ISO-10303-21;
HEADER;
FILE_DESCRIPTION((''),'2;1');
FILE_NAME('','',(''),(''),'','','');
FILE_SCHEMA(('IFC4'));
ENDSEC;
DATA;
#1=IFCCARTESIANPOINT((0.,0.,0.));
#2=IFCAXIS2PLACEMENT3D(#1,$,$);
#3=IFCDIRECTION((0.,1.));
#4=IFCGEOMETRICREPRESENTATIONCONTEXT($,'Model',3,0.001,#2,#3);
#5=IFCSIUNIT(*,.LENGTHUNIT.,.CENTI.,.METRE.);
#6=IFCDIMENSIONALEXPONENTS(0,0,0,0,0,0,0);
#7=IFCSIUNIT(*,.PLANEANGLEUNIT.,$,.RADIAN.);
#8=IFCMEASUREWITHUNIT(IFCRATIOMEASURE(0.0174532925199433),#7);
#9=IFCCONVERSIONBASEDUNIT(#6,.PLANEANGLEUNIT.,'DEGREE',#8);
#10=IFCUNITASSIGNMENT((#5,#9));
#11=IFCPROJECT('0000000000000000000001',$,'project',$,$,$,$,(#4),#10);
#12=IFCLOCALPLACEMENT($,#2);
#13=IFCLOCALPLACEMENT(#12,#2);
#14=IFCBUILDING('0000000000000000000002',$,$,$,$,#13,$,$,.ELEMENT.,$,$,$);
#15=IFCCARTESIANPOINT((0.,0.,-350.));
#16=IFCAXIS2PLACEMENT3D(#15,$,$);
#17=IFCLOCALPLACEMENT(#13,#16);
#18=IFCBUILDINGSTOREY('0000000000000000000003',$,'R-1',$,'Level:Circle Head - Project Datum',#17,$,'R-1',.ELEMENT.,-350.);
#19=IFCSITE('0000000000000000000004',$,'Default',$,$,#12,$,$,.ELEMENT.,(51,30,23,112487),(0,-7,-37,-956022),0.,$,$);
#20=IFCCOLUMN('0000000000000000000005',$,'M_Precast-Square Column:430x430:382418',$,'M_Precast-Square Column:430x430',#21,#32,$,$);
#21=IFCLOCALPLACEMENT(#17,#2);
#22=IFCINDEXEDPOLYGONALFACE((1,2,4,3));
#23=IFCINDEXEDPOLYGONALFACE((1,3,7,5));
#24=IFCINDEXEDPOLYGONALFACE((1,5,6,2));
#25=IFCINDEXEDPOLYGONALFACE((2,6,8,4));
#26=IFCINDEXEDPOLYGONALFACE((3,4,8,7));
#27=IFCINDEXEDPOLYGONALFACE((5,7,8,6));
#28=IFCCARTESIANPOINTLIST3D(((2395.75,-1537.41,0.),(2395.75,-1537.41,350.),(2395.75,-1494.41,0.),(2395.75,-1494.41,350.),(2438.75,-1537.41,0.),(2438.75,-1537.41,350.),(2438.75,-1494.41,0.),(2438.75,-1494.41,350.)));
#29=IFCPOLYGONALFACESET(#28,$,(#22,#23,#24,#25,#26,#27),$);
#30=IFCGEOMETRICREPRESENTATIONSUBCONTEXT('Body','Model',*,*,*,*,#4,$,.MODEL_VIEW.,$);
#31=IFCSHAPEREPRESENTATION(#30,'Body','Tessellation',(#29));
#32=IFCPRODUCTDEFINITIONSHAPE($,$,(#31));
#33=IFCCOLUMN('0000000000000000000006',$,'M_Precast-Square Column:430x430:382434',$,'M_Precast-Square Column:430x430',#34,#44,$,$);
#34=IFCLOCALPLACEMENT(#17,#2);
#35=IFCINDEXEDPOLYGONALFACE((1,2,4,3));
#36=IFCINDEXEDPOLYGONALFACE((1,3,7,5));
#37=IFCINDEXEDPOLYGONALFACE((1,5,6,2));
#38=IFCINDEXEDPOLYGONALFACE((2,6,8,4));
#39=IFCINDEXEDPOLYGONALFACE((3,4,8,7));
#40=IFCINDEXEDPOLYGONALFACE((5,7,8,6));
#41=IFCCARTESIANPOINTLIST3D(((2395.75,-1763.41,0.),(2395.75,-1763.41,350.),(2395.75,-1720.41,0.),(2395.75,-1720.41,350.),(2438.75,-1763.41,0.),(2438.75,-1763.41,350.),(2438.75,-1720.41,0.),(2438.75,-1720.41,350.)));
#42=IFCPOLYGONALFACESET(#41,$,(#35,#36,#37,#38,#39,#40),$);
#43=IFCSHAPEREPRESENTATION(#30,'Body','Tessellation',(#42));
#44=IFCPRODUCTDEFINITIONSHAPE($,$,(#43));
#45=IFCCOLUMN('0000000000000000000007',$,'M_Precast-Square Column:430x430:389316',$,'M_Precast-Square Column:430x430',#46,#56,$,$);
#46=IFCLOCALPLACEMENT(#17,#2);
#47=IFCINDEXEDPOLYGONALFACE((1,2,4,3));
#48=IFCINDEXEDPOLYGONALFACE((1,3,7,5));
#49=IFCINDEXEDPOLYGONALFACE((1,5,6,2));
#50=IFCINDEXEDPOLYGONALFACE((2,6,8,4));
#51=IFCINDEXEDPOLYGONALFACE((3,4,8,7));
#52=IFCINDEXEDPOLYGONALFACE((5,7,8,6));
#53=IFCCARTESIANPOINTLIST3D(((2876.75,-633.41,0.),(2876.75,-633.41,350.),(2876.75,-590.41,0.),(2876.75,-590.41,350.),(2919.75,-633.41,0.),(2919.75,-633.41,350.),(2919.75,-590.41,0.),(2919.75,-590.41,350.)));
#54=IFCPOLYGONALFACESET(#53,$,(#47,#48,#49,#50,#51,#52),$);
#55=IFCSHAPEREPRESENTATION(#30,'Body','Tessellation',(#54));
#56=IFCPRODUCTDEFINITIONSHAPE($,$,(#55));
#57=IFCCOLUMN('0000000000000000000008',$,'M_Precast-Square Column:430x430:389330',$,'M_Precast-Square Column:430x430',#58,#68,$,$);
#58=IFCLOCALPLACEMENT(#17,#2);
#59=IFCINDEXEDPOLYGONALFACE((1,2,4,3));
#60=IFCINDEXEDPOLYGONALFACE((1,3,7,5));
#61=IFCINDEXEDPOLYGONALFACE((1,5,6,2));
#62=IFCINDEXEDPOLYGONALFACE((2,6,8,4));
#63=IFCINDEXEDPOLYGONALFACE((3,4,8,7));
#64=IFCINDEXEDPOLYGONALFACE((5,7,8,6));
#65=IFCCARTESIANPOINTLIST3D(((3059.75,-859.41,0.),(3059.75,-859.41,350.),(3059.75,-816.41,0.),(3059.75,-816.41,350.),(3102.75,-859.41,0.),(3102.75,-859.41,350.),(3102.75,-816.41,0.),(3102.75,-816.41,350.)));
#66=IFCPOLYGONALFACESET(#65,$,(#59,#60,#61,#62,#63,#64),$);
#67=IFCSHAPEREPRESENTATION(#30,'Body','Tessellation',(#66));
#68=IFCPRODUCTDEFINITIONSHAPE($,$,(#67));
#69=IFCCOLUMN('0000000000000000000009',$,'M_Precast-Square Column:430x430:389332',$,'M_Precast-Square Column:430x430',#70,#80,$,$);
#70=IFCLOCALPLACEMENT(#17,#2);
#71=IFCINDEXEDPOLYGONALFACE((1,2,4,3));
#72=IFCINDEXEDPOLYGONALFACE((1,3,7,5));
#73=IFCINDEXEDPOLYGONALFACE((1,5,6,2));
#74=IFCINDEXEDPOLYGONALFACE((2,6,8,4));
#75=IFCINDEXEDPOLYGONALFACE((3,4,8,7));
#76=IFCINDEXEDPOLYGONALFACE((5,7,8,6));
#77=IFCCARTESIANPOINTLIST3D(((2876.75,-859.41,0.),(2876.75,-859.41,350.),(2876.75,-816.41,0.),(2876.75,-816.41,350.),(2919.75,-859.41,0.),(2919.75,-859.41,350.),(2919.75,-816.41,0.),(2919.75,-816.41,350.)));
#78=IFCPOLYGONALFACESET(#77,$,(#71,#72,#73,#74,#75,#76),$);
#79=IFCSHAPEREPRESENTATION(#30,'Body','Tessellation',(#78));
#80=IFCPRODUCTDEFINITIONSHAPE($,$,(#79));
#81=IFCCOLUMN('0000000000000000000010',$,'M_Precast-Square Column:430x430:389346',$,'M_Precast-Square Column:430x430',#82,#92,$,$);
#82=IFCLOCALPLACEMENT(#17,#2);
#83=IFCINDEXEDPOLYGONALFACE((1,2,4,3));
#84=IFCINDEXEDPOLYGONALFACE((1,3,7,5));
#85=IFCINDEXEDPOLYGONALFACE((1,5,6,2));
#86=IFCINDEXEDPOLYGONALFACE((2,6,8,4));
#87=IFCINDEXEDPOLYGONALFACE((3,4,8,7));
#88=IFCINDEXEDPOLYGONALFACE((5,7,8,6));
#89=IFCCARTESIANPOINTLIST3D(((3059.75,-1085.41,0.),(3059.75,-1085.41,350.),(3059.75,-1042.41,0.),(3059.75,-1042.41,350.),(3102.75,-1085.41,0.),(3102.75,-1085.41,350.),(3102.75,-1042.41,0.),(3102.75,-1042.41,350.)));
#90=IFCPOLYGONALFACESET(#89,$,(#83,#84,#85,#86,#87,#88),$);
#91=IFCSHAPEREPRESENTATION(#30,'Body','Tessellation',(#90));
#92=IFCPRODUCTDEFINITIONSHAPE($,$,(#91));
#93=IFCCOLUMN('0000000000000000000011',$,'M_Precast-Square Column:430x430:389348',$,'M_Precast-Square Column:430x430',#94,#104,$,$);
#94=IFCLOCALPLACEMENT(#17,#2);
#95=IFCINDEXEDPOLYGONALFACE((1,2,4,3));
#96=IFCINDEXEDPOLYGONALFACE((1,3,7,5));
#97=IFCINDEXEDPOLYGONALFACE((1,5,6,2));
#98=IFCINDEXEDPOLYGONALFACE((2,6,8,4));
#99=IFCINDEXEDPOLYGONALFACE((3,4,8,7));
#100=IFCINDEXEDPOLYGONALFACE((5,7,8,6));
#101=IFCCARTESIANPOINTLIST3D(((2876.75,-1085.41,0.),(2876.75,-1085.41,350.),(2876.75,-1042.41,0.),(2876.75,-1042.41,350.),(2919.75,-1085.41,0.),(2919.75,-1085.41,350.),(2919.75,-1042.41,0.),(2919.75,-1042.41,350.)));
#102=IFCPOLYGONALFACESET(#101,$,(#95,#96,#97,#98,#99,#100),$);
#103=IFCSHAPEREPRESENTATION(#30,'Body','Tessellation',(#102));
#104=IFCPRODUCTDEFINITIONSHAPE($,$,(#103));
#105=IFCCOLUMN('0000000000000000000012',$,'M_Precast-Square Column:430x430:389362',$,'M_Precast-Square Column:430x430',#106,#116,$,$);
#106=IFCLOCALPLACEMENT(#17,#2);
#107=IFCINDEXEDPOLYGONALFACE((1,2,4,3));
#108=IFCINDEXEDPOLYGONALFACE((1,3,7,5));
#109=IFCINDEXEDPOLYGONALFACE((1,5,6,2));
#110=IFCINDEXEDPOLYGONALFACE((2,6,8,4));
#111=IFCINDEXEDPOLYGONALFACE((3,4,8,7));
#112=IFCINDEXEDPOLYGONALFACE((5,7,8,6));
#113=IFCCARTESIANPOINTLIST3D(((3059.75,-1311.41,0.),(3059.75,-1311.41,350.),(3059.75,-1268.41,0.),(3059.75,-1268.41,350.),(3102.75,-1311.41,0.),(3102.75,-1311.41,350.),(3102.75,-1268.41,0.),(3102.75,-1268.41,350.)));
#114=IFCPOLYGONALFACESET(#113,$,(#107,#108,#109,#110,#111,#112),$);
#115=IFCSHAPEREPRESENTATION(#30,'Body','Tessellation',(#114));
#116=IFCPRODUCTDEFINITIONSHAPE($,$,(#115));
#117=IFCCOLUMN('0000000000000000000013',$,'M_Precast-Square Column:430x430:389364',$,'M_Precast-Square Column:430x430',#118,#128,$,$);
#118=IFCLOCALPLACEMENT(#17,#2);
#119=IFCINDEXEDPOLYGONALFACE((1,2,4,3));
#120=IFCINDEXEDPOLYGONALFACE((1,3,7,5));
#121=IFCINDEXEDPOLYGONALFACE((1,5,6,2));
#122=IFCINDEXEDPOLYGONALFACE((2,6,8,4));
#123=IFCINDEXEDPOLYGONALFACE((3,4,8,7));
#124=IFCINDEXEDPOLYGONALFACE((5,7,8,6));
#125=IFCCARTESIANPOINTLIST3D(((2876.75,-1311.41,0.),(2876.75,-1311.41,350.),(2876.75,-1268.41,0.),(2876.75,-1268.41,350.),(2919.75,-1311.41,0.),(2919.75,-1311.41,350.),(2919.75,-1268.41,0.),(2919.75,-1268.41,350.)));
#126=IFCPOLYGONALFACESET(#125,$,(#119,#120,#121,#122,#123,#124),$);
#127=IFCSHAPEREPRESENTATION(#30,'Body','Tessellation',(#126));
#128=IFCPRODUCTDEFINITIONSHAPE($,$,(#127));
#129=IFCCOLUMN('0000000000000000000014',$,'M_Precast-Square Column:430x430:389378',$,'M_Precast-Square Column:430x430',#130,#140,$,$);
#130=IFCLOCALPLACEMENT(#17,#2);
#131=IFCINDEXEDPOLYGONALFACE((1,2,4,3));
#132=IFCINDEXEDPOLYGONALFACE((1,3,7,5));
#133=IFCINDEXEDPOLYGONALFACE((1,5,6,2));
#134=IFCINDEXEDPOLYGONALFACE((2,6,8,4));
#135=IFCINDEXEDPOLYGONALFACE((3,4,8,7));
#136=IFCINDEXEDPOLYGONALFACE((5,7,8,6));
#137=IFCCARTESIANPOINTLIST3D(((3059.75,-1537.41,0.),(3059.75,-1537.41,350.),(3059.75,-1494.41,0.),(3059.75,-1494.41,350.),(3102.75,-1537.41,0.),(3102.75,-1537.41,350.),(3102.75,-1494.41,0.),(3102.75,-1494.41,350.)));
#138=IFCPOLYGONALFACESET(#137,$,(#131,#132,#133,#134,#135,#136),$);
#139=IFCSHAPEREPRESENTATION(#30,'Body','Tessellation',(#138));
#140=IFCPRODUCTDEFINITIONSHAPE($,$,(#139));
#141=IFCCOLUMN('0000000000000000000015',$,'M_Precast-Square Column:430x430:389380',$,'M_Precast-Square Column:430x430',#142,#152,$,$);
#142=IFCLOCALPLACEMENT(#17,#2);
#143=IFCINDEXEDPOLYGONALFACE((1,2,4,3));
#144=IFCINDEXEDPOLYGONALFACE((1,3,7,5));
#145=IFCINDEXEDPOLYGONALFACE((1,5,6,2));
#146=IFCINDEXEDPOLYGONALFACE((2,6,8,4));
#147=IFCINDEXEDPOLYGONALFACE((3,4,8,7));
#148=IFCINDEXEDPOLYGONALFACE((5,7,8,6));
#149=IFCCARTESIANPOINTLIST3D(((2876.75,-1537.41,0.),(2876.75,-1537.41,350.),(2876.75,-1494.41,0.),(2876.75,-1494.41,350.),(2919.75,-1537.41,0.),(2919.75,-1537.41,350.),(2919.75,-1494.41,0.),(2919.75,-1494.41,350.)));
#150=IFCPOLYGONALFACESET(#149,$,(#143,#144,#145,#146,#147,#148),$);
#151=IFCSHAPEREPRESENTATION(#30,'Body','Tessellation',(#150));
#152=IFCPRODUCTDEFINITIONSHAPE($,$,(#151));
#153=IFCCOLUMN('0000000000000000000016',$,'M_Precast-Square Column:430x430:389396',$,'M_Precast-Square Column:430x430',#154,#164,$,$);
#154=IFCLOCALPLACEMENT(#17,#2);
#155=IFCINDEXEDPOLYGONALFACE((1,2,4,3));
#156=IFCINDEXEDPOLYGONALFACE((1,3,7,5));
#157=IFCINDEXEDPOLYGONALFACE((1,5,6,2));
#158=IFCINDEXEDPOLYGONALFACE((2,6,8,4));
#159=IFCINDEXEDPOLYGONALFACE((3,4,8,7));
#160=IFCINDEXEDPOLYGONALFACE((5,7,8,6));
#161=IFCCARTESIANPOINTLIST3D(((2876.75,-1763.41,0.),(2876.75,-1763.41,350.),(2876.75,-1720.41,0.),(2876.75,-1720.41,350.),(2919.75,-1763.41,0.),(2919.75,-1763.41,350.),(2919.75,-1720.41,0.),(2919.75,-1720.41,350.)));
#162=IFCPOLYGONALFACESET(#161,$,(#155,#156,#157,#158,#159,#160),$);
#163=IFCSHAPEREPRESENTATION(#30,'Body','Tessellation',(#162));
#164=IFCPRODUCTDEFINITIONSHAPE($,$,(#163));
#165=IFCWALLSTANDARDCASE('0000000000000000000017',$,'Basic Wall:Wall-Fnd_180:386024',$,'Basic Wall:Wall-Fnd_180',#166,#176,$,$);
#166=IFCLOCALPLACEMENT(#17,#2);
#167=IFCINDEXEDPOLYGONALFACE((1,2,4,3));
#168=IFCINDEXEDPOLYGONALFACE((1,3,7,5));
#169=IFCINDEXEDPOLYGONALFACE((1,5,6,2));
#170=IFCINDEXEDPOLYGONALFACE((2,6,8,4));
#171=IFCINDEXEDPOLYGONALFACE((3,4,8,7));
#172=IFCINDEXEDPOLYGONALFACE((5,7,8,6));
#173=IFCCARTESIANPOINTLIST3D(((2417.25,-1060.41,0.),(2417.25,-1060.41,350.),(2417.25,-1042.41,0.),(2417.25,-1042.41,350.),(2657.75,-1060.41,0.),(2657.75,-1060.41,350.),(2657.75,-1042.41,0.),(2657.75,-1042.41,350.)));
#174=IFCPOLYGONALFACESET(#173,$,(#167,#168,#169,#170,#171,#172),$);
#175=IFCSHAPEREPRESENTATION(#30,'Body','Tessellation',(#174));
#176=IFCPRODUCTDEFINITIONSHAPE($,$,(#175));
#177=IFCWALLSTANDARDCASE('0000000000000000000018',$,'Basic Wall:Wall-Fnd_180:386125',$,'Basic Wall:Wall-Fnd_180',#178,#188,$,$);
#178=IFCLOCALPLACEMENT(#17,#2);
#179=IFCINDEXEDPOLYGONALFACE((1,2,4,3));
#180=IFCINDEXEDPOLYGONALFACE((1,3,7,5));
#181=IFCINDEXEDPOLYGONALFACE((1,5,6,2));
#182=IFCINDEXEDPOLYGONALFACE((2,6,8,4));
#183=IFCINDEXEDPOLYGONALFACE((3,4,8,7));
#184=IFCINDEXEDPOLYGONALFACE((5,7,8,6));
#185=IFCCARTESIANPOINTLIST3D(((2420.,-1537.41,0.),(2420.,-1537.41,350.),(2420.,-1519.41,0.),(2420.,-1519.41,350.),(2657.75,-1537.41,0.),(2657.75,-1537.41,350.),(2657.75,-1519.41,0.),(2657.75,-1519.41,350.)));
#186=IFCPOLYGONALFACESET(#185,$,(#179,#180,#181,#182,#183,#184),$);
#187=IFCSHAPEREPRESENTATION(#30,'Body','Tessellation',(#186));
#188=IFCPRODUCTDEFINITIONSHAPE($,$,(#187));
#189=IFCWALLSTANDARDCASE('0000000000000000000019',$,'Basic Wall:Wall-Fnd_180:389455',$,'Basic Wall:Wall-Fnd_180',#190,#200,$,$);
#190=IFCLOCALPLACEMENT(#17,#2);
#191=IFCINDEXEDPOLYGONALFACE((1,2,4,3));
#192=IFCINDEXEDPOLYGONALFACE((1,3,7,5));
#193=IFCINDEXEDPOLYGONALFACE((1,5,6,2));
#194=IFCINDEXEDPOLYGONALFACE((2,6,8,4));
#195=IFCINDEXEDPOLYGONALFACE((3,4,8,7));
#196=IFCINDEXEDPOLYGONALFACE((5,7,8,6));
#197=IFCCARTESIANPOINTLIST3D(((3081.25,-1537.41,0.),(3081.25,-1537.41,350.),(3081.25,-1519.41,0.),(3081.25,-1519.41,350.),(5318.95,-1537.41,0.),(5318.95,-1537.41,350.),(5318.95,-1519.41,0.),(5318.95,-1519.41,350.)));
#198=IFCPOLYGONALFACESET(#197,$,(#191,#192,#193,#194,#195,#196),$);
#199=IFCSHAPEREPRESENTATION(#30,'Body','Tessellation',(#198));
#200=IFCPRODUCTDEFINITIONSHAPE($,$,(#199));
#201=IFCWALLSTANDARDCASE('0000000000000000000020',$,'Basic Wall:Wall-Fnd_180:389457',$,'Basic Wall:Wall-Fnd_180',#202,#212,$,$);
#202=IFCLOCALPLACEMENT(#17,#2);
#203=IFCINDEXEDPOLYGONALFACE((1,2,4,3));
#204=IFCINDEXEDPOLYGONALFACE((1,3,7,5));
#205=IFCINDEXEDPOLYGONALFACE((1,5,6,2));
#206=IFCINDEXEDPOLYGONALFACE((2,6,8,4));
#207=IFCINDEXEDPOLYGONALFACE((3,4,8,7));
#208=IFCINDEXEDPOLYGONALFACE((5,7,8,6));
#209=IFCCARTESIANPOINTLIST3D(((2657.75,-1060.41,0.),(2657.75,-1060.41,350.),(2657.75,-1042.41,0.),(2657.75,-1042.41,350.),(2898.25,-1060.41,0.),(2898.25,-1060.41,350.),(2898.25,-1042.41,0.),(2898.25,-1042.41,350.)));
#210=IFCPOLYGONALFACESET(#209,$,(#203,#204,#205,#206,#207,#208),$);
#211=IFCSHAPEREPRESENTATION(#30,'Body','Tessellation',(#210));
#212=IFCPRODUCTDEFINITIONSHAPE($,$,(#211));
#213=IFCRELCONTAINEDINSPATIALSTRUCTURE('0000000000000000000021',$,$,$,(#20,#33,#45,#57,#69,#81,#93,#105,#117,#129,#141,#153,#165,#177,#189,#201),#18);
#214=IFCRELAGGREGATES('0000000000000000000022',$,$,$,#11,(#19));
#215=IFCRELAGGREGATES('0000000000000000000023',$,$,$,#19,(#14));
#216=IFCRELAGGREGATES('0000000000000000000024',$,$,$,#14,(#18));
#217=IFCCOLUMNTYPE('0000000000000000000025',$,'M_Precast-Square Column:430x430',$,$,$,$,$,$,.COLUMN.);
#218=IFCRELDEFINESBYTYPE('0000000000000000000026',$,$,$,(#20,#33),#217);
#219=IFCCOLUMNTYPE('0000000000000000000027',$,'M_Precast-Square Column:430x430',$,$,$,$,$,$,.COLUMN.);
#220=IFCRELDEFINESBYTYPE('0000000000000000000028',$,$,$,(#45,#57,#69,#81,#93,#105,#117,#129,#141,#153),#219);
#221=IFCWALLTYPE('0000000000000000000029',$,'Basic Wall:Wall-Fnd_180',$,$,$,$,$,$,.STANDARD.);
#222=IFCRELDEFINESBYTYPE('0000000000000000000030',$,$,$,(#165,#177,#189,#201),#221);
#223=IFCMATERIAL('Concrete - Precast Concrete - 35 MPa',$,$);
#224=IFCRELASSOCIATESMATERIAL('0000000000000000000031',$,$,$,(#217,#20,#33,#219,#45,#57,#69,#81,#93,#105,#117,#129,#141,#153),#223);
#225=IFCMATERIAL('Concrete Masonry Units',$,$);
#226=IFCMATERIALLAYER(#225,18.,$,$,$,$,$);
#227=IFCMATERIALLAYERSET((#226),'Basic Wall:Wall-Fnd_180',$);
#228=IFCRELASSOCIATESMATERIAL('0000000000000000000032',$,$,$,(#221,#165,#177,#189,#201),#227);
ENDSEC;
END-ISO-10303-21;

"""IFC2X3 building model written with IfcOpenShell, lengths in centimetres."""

from ifc_helpers import new_model, entity, si_unit, converted_unit, direction, frame, frame_2d, origin, origin_2d_with_axis, place, context, subcontext, project, spatial, rectangle, extrude, source, transform, mapped, material, layer, layer_set, layer_usage, type_object, type_shapes, element, save


model = new_model("IFC2X3")

# Units and contexts
model_context = context("Model", 3, precision=0.001, world=origin(), true_north=direction((0.0, 1.0)))
body_context = subcontext(model_context, "Body", "Model", "MODEL_VIEW")
ifc_project = project(units=[si_unit("LENGTHUNIT", "METRE", prefix="CENTI"), converted_unit("PLANEANGLEUNIT", "DEGREE", entity("IfcRatioMeasure", 0.0174532925199433), si_unit("PLANEANGLEUNIT", "RADIAN"), dimensions=[0, 0, 0, 0, 0, 0, 0])], contexts=[model_context])

# Site, building, storey
site_placement = place(None, origin())
site = spatial("IfcSite", under=ifc_project, at=site_placement, Name="Default", CompositionType="ELEMENT", RefLatitude=(51, 30, 23, 112487), RefLongitude=(0, -7, -37, -956022), RefElevation=0.0)
building_placement = place(site_placement, origin())
building = spatial("IfcBuilding", under=site, at=building_placement, CompositionType="ELEMENT")
storey_placement = place(building_placement, frame((0.0, 0.0, -350.0)))
storey = spatial("IfcBuildingStorey", under=building, at=storey_placement, Name="R-1", ObjectType="Level:Circle Head - Project Datum", LongName="R-1", CompositionType="ELEMENT", Elevation=-350.0)

# Columns
ifc_material_1 = material(Name="Concrete - Precast Concrete - 35 MPa")
column_type_1 = type_object("IfcColumnType", Name="M_Precast-Square Column:430x430", PredefinedType="COLUMN", material=ifc_material_1)
shared_shape_1 = source(origin(), body_context, "Body", "SweptSolid", [
    extrude(rectangle(XDim=43.0, YDim=43.0, at=origin_2d_with_axis()), frame((0.0, 0.0, -350.0), z_axis=(0.0, 0.0, 1.0), x_axis=(0.0, -1.0, 0.0)), (0.0, 0.0, 1.0), 350.0),
])
type_shapes(column_type_1, [shared_shape_1])
for number, where, z_axis, x_axis, name in (
    (1, (2417.25, -1515.91, 350.0), (0.0, 0.0, 1.0), (-1.0, 0.0, 0.0), "M_Precast-Square Column:430x430:382418"),
    (2, (2417.25, -1741.91, 350.0), (0.0, 0.0, 1.0), (-1.0, 0.0, 0.0), "M_Precast-Square Column:430x430:382434"),
):
    element("IfcColumn", number, at=place(storey_placement, frame(where, z_axis=z_axis, x_axis=x_axis)), inside=storey, type_object=column_type_1, material=ifc_material_1, Name=name, ObjectType="M_Precast-Square Column:430x430", context=body_context, shape_type="MappedRepresentation", body=[
        mapped(shared_shape_1, transform((0.0, 0.0, 0.0), scale=1.0)),
    ])
column_type_2 = type_object("IfcColumnType", Name="M_Precast-Square Column:430x430", PredefinedType="COLUMN", material=ifc_material_1)
shared_shape_2 = source(origin(), body_context, "Body", "SweptSolid", [
    extrude(rectangle(XDim=43.0, YDim=43.0, at=origin_2d_with_axis()), frame((0.0, 0.0, -350.0), z_axis=(0.0, 0.0, 1.0), x_axis=(0.0, -1.0, 0.0)), (0.0, 0.0, 1.0), 350.0),
])
type_shapes(column_type_2, [shared_shape_2])
for number, where, name in (
    (3, (2898.25, -611.91, 350.0), "M_Precast-Square Column:430x430:389316"),
    (4, (3081.25, -837.91, 350.0), "M_Precast-Square Column:430x430:389330"),
    (5, (2898.25, -837.91, 350.0), "M_Precast-Square Column:430x430:389332"),
    (6, (3081.25, -1063.91, 350.0), "M_Precast-Square Column:430x430:389346"),
    (7, (2898.25, -1063.91, 350.0), "M_Precast-Square Column:430x430:389348"),
    (8, (3081.25, -1289.91, 350.0), "M_Precast-Square Column:430x430:389362"),
    (9, (2898.25, -1289.91, 350.0), "M_Precast-Square Column:430x430:389364"),
    (10, (3081.25, -1515.91, 350.0), "M_Precast-Square Column:430x430:389378"),
    (11, (2898.25, -1515.91, 350.0), "M_Precast-Square Column:430x430:389380"),
    (12, (2898.25, -1741.91, 350.0), "M_Precast-Square Column:430x430:389396"),
):
    element("IfcColumn", number, at=place(storey_placement, frame(where)), inside=storey, type_object=column_type_2, material=ifc_material_1, Name=name, ObjectType="M_Precast-Square Column:430x430", context=body_context, shape_type="MappedRepresentation", body=[
        mapped(shared_shape_2, transform((0.0, 0.0, 0.0), scale=1.0)),
    ])

# Walls
ifc_material_2 = material(Name="Concrete Masonry Units")
ifc_layer_1 = layer(ifc_material_2, 18.0)
ifc_layer_set_1 = layer_set([ifc_layer_1], Name="Basic Wall:Wall-Fnd_180")
ifc_layer_usage_1 = layer_usage(ifc_layer_set_1, "AXIS2", "NEGATIVE", 9.0)
wall_type_1 = type_object("IfcWallType", Name="Basic Wall:Wall-Fnd_180", PredefinedType="STANDARD", material=ifc_layer_set_1)
wall_1_placement = place(storey_placement, frame((2417.25, -1051.41, 0.0)))
element("IfcWallStandardCase", 13, at=wall_1_placement, inside=storey, type_object=wall_type_1, material=ifc_layer_usage_1, Name="Basic Wall:Wall-Fnd_180:386024", ObjectType="Basic Wall:Wall-Fnd_180", context=body_context, shape_type="SweptSolid", body=[
    extrude(rectangle(XDim=240.5, YDim=18.0, at=frame_2d((120.25, 0.0), x_axis=(-1.0, 0.0))), origin(), (0.0, 0.0, 1.0), 350.0),
])
ifc_layer_usage_2 = layer_usage(ifc_layer_set_1, "AXIS2", "POSITIVE", -9.0)
wall_2_placement = place(storey_placement, frame((2420.0, -1528.41, 0.0)))
element("IfcWallStandardCase", 14, at=wall_2_placement, inside=storey, type_object=wall_type_1, material=ifc_layer_usage_2, Name="Basic Wall:Wall-Fnd_180:386125", ObjectType="Basic Wall:Wall-Fnd_180", context=body_context, shape_type="SweptSolid", body=[
    extrude(rectangle(XDim=237.75, YDim=18.0, at=frame_2d((118.88, 0.0), x_axis=(-1.0, 0.0))), origin(), (0.0, 0.0, 1.0), 350.0),
])
ifc_layer_usage_3 = layer_usage(ifc_layer_set_1, "AXIS2", "POSITIVE", -9.0)
wall_3_placement = place(storey_placement, frame((3081.25, -1528.41, 0.0)))
element("IfcWallStandardCase", 15, at=wall_3_placement, inside=storey, type_object=wall_type_1, material=ifc_layer_usage_3, Name="Basic Wall:Wall-Fnd_180:389455", ObjectType="Basic Wall:Wall-Fnd_180", context=body_context, shape_type="SweptSolid", body=[
    extrude(rectangle(XDim=2237.7, YDim=18.0, at=frame_2d((1118.85, 0.0), x_axis=(-1.0, 0.0))), origin(), (0.0, 0.0, 1.0), 350.0),
])
ifc_layer_usage_4 = layer_usage(ifc_layer_set_1, "AXIS2", "POSITIVE", -9.0)
wall_4_placement = place(storey_placement, frame((2898.25, -1051.41, 0.0), z_axis=(0.0, 0.0, 1.0), x_axis=(-1.0, 0.0, 0.0)))
element("IfcWallStandardCase", 16, at=wall_4_placement, inside=storey, type_object=wall_type_1, material=ifc_layer_usage_4, Name="Basic Wall:Wall-Fnd_180:389457", ObjectType="Basic Wall:Wall-Fnd_180", context=body_context, shape_type="SweptSolid", body=[
    extrude(rectangle(XDim=240.5, YDim=18.0, at=frame_2d((120.25, 0.0), x_axis=(-1.0, 0.0))), origin(), (0.0, 0.0, 1.0), 350.0),
])

save(model, "model.ifc")
